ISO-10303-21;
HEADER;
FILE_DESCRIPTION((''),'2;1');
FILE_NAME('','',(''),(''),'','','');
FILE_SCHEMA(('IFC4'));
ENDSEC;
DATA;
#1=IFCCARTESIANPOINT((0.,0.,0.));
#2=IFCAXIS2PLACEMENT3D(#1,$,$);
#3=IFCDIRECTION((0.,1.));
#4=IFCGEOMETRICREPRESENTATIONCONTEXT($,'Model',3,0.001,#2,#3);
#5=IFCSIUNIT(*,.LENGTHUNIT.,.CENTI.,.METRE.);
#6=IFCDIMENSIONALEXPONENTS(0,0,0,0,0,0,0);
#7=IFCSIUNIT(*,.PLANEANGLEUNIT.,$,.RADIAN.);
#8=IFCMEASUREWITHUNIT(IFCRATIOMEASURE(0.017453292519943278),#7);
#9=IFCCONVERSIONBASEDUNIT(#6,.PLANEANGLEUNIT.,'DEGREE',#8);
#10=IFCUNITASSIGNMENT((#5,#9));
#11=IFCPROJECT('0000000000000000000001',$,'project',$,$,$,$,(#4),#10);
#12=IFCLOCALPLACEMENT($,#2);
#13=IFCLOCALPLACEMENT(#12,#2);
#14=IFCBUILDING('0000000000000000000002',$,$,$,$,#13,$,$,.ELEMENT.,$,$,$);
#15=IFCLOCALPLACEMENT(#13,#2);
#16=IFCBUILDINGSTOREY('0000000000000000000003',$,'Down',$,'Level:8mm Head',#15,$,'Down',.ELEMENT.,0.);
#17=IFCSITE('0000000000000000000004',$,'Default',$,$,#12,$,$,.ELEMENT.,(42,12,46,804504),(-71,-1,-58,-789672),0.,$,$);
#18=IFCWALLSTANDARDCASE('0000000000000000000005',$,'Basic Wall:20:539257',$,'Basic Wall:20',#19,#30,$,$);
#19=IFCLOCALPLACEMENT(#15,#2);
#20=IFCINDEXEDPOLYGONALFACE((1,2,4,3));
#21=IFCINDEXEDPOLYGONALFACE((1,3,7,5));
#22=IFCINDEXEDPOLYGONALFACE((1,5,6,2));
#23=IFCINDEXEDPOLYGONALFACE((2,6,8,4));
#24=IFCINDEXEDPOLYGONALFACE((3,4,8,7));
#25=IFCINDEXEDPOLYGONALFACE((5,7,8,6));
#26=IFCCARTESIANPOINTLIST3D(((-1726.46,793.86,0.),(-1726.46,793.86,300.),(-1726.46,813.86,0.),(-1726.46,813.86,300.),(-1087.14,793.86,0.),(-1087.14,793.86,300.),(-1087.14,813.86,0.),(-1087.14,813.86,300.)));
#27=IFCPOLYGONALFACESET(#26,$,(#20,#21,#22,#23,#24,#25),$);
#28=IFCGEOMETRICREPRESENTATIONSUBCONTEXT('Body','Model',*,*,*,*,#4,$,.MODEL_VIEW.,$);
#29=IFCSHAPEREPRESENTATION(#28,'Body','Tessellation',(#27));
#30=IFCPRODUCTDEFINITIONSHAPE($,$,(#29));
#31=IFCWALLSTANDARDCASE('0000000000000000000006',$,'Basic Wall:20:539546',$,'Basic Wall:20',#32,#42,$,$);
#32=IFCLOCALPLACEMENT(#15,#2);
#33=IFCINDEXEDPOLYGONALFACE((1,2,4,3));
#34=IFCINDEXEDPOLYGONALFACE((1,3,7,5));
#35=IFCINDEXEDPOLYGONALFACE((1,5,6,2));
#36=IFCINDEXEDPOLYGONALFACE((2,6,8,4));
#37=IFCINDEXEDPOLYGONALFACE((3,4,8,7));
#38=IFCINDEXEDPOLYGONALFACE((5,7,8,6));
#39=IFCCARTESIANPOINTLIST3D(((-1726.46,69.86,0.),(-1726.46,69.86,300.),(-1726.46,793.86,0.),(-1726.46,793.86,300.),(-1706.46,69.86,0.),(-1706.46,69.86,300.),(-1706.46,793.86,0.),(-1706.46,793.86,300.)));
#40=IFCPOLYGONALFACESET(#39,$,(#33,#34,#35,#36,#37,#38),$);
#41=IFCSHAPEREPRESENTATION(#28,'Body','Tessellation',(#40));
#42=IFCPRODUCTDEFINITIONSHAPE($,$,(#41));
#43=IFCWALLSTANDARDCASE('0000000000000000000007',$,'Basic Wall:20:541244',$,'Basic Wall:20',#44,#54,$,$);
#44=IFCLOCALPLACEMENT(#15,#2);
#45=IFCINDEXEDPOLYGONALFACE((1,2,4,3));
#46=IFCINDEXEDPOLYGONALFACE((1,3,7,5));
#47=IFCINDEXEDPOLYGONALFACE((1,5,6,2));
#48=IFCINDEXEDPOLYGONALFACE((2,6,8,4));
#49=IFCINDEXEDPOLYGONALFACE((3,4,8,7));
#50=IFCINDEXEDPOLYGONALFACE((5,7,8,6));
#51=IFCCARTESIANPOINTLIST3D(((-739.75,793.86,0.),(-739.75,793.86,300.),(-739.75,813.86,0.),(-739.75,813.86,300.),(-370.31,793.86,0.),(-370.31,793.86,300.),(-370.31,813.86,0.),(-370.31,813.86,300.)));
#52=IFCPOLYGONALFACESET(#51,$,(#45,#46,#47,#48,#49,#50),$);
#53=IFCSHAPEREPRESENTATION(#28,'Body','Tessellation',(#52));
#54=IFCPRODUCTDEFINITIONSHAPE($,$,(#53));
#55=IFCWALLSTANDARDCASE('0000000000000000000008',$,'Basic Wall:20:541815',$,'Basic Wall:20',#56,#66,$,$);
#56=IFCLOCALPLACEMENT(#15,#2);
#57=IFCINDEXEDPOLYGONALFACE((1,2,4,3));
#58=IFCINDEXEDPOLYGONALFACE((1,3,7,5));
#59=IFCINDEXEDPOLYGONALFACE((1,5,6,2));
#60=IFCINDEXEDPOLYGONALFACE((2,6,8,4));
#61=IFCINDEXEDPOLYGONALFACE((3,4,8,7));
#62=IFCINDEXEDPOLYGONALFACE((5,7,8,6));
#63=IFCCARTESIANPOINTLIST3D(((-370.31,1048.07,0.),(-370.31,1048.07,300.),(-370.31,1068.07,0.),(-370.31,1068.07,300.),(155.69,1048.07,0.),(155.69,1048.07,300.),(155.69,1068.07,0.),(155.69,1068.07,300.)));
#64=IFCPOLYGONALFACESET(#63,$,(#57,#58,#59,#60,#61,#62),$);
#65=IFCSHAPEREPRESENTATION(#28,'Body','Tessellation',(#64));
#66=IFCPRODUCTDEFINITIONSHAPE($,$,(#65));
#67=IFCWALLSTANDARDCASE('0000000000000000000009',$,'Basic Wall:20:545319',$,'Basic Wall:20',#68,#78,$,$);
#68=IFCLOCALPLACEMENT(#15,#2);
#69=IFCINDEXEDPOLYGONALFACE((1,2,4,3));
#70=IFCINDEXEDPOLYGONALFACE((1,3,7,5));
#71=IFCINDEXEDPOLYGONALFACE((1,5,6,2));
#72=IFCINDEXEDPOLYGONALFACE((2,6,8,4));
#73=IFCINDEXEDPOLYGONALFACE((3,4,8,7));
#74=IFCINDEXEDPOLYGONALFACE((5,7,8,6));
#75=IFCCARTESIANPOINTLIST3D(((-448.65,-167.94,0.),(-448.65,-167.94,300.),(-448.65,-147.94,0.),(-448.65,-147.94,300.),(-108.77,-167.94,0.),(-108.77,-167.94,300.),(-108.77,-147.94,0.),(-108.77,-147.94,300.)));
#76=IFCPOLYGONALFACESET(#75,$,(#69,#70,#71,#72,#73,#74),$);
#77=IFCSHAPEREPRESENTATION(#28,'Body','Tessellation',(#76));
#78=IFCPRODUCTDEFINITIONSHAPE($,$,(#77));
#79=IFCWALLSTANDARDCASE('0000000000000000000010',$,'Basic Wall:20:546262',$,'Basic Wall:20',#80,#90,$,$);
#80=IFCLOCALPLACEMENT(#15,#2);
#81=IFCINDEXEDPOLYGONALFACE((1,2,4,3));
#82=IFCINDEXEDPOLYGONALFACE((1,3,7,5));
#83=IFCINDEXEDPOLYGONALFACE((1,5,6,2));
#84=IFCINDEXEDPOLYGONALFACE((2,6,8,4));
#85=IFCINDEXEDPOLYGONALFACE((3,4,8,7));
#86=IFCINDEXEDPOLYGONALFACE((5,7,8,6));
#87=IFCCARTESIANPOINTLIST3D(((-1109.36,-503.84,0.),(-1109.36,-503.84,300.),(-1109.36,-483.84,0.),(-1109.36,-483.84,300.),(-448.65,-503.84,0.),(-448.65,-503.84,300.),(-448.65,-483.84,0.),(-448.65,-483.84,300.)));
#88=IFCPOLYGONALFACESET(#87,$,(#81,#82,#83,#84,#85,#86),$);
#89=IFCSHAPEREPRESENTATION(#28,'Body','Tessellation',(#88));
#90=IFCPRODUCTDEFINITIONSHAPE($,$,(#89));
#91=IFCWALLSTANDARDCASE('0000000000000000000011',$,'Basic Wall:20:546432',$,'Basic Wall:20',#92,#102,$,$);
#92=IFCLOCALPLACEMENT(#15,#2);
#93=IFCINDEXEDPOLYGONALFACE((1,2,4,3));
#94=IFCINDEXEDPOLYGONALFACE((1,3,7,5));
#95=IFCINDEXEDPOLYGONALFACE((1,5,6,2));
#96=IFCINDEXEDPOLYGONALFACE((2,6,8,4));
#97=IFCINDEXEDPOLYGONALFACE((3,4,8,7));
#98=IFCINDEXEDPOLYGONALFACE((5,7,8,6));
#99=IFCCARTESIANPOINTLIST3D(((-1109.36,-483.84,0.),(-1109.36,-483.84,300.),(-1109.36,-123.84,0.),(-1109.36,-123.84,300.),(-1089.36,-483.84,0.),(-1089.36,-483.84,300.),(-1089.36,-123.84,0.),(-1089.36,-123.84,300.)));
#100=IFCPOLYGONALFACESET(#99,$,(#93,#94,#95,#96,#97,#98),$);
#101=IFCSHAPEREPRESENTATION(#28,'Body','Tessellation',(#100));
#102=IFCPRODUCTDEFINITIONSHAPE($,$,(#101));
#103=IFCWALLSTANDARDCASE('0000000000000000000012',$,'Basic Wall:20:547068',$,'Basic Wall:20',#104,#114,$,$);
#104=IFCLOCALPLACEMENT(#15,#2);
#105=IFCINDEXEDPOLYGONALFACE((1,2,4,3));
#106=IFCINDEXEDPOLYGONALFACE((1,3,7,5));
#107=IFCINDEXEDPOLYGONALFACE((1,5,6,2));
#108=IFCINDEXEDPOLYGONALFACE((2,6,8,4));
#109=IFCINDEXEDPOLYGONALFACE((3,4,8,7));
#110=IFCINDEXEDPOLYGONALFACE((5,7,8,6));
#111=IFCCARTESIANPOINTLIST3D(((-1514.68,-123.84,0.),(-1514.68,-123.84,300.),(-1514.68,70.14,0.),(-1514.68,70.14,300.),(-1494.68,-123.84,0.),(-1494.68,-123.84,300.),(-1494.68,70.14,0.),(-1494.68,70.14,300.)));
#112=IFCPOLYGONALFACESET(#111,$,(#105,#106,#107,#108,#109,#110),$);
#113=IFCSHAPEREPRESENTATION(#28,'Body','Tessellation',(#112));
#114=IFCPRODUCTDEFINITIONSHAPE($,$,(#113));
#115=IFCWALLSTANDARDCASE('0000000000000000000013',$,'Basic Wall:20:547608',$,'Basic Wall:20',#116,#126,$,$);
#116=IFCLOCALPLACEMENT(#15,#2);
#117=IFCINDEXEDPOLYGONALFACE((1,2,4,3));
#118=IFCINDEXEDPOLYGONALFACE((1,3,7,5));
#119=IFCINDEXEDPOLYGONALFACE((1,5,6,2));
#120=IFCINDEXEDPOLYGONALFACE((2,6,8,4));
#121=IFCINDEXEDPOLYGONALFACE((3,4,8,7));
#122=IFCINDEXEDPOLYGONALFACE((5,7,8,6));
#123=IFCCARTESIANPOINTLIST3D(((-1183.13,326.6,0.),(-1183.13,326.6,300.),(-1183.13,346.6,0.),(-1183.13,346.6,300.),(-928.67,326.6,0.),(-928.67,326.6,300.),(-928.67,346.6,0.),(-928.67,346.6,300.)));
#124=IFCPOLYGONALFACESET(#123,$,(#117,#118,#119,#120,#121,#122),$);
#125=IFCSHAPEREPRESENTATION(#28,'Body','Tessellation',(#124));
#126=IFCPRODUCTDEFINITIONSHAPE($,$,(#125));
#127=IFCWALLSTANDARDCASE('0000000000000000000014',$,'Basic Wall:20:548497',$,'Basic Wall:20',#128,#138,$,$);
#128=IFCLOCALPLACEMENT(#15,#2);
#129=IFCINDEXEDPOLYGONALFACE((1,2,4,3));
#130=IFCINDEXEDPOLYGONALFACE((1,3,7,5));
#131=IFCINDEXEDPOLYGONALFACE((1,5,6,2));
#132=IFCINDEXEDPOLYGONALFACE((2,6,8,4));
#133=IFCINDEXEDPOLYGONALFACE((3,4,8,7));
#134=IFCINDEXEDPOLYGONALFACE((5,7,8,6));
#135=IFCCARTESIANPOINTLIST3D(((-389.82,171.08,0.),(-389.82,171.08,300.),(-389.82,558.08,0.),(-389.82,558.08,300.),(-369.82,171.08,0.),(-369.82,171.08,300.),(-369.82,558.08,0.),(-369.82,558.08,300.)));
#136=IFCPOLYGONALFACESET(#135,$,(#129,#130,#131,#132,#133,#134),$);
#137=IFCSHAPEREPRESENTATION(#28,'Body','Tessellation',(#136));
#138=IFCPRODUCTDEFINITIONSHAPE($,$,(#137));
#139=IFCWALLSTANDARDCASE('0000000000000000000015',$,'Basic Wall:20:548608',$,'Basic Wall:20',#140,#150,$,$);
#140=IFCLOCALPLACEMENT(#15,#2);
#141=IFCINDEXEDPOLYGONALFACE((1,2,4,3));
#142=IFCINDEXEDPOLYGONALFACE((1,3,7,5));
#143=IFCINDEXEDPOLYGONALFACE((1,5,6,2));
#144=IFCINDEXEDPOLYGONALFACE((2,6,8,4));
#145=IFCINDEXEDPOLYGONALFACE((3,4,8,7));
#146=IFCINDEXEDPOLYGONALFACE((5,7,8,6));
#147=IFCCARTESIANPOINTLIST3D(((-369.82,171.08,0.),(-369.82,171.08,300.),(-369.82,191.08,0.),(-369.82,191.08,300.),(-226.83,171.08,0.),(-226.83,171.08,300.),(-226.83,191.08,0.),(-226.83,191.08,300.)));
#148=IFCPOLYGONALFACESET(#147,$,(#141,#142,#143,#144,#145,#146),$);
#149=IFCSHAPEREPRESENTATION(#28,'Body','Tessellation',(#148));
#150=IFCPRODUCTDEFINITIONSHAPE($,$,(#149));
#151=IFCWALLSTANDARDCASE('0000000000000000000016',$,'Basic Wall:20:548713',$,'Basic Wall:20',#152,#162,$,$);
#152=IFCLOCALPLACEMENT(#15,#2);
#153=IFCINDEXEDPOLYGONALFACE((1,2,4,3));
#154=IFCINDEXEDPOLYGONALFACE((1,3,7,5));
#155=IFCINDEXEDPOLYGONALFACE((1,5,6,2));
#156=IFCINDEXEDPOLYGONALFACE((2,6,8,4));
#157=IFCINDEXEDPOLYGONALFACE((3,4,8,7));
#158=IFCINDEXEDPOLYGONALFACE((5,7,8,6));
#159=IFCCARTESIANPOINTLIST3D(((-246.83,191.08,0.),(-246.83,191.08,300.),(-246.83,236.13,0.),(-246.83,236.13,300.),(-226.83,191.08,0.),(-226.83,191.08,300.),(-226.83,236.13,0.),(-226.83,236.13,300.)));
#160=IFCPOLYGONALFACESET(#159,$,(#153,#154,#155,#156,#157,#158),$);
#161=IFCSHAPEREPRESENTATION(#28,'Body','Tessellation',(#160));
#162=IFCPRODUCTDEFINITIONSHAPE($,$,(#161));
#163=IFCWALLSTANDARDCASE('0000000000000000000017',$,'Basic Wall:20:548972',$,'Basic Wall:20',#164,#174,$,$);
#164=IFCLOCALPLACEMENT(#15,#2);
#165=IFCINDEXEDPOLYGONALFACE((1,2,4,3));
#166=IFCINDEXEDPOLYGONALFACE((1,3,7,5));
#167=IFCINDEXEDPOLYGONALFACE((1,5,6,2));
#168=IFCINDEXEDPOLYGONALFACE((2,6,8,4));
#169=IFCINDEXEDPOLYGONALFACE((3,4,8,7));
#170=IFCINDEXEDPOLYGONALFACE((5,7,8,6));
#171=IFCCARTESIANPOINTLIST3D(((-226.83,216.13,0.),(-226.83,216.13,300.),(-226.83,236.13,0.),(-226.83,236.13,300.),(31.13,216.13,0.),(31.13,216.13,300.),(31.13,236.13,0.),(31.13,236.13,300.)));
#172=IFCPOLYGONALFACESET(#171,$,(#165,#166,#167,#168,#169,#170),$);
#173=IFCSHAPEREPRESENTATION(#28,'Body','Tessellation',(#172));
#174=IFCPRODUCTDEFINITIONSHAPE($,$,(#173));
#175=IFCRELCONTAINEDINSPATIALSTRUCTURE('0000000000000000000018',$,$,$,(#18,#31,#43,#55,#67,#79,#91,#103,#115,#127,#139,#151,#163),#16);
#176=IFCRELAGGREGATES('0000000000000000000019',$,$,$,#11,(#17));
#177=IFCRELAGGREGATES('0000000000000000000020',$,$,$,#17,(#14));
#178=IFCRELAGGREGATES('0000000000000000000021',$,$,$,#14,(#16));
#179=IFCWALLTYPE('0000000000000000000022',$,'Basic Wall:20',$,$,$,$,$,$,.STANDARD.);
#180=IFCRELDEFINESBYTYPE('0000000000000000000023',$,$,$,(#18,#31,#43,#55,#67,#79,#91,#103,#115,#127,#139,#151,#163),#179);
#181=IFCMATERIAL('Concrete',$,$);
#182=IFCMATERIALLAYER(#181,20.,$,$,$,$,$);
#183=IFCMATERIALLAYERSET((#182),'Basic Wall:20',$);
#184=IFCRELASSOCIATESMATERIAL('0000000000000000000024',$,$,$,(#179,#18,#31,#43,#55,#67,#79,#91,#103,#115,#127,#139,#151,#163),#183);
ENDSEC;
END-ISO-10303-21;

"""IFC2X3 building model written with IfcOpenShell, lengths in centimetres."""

from ifc_helpers import new_model, entity, si_unit, converted_unit, direction, frame, frame_2d, origin, place, context, subcontext, project, spatial, rectangle, extrude, material, layer, layer_set, layer_usage, type_object, element, save


model = new_model("IFC2X3")

# Units and contexts
model_context = context("Model", 3, precision=0.001, world=origin(), true_north=direction((0.0, 1.0)))
body_context = subcontext(model_context, "Body", "Model", "MODEL_VIEW")
ifc_project = project(units=[si_unit("LENGTHUNIT", "METRE", prefix="CENTI"), converted_unit("PLANEANGLEUNIT", "DEGREE", entity("IfcRatioMeasure", 0.017453292519943278), si_unit("PLANEANGLEUNIT", "RADIAN"), dimensions=[0, 0, 0, 0, 0, 0, 0])], contexts=[model_context])

# Site, building, storey
site_placement = place(None, origin())
site = spatial("IfcSite", under=ifc_project, at=site_placement, Name="Default", CompositionType="ELEMENT", RefLatitude=(42, 12, 46, 804504), RefLongitude=(-71, -1, -58, -789672), RefElevation=0.0)
building_placement = place(site_placement, origin())
building = spatial("IfcBuilding", under=site, at=building_placement, CompositionType="ELEMENT")
storey_placement = place(building_placement, origin())
storey = spatial("IfcBuildingStorey", under=building, at=storey_placement, Name="Down", ObjectType="Level:8mm Head", LongName="Down", CompositionType="ELEMENT", Elevation=0.0)

# Walls
ifc_material = material(Name="Concrete")
ifc_layer_1 = layer(ifc_material, 20.0)
ifc_layer_set_1 = layer_set([ifc_layer_1], Name="Basic Wall:20")
ifc_layer_usage_1 = layer_usage(ifc_layer_set_1, "AXIS2", "NEGATIVE", 10.0)
wall_type_1 = type_object("IfcWallType", Name="Basic Wall:20", PredefinedType="STANDARD", material=ifc_layer_set_1)
wall_1_placement = place(storey_placement, frame((-1726.46, 803.86, 0.0)))
element("IfcWallStandardCase", 1, at=wall_1_placement, inside=storey, type_object=wall_type_1, material=ifc_layer_usage_1, Name="Basic Wall:20:539257", ObjectType="Basic Wall:20", context=body_context, shape_type="SweptSolid", body=[
    extrude(rectangle(XDim=639.32, YDim=20.0, at=frame_2d((319.66, 0.0), x_axis=(-1.0, 0.0))), origin(), (0.0, 0.0, 1.0), 300.0),
])
ifc_layer_usage_2 = layer_usage(ifc_layer_set_1, "AXIS2", "POSITIVE", -10.0)
wall_2_placement = place(storey_placement, frame((-1716.46, 793.86, 0.0), z_axis=(0.0, 0.0, 1.0), x_axis=(0.0, -1.0, 0.0)))
element("IfcWallStandardCase", 2, at=wall_2_placement, inside=storey, type_object=wall_type_1, material=ifc_layer_usage_2, Name="Basic Wall:20:539546", ObjectType="Basic Wall:20", context=body_context, shape_type="SweptSolid", body=[
    extrude(rectangle(XDim=724.0, YDim=20.0, at=frame_2d((362.0, 0.0), x_axis=(-1.0, 0.0))), origin(), (0.0, 0.0, 1.0), 300.0),
])
ifc_layer_usage_3 = layer_usage(ifc_layer_set_1, "AXIS2", "NEGATIVE", 10.0)
wall_3_placement = place(storey_placement, frame((-739.75, 803.86, 0.0)))
element("IfcWallStandardCase", 3, at=wall_3_placement, inside=storey, type_object=wall_type_1, material=ifc_layer_usage_3, Name="Basic Wall:20:541244", ObjectType="Basic Wall:20", context=body_context, shape_type="SweptSolid", body=[
    extrude(rectangle(XDim=369.44, YDim=20.0, at=frame_2d((184.72, 0.0), x_axis=(-1.0, 0.0))), origin(), (0.0, 0.0, 1.0), 300.0),
])
ifc_layer_usage_4 = layer_usage(ifc_layer_set_1, "AXIS2", "NEGATIVE", 10.0)
wall_4_placement = place(storey_placement, frame((-370.31, 1058.07, 0.0)))
element("IfcWallStandardCase", 4, at=wall_4_placement, inside=storey, type_object=wall_type_1, material=ifc_layer_usage_4, Name="Basic Wall:20:541815", ObjectType="Basic Wall:20", context=body_context, shape_type="SweptSolid", body=[
    extrude(rectangle(XDim=526.0, YDim=20.0, at=frame_2d((263.0, 0.0), x_axis=(-1.0, 0.0))), origin(), (0.0, 0.0, 1.0), 300.0),
])
ifc_layer_usage_5 = layer_usage(ifc_layer_set_1, "AXIS2", "POSITIVE", -10.0)
wall_5_placement = place(storey_placement, frame((-108.77, -157.94, 0.0), z_axis=(0.0, 0.0, 1.0), x_axis=(-1.0, 0.0, 0.0)))
element("IfcWallStandardCase", 5, at=wall_5_placement, inside=storey, type_object=wall_type_1, material=ifc_layer_usage_5, Name="Basic Wall:20:545319", ObjectType="Basic Wall:20", context=body_context, shape_type="SweptSolid", body=[
    extrude(rectangle(XDim=339.88, YDim=20.0, at=frame_2d((169.94, 0.0), x_axis=(-1.0, 0.0))), origin(), (0.0, 0.0, 1.0), 300.0),
])
ifc_layer_usage_6 = layer_usage(ifc_layer_set_1, "AXIS2", "NEGATIVE", 10.0)
wall_6_placement = place(storey_placement, frame((-448.65, -493.84, 0.0), z_axis=(0.0, 0.0, 1.0), x_axis=(-1.0, 0.0, 0.0)))
element("IfcWallStandardCase", 6, at=wall_6_placement, inside=storey, type_object=wall_type_1, material=ifc_layer_usage_6, Name="Basic Wall:20:546262", ObjectType="Basic Wall:20", context=body_context, shape_type="SweptSolid", body=[
    extrude(rectangle(XDim=660.71, YDim=20.0, at=frame_2d((330.36, 0.0), x_axis=(-1.0, 0.0))), origin(), (0.0, 0.0, 1.0), 300.0),
])
ifc_layer_usage_7 = layer_usage(ifc_layer_set_1, "AXIS2", "NEGATIVE", 10.0)
wall_7_placement = place(storey_placement, frame((-1099.36, -483.84, 0.0), z_axis=(0.0, 0.0, 1.0), x_axis=(0.0, 1.0, 0.0)))
element("IfcWallStandardCase", 7, at=wall_7_placement, inside=storey, type_object=wall_type_1, material=ifc_layer_usage_7, Name="Basic Wall:20:546432", ObjectType="Basic Wall:20", context=body_context, shape_type="SweptSolid", body=[
    extrude(rectangle(XDim=360.0, YDim=20.0, at=frame_2d((180.0, 0.0), x_axis=(-1.0, 0.0))), origin(), (0.0, 0.0, 1.0), 300.0),
])
ifc_layer_usage_8 = layer_usage(ifc_layer_set_1, "AXIS2", "POSITIVE", -10.0)
wall_8_placement = place(storey_placement, frame((-1504.68, -123.84, 0.0), z_axis=(0.0, 0.0, 1.0), x_axis=(0.0, 1.0, 0.0)))
element("IfcWallStandardCase", 8, at=wall_8_placement, inside=storey, type_object=wall_type_1, material=ifc_layer_usage_8, Name="Basic Wall:20:547068", ObjectType="Basic Wall:20", context=body_context, shape_type="SweptSolid", body=[
    extrude(rectangle(XDim=193.98, YDim=20.0, at=frame_2d((96.99, 0.0), x_axis=(-1.0, 0.0))), origin(), (0.0, 0.0, 1.0), 300.0),
])
ifc_layer_usage_9 = layer_usage(ifc_layer_set_1, "AXIS2", "NEGATIVE", 10.0)
wall_9_placement = place(storey_placement, frame((-928.67, 336.6, 0.0), z_axis=(0.0, 0.0, 1.0), x_axis=(-1.0, 0.0, 0.0)))
element("IfcWallStandardCase", 9, at=wall_9_placement, inside=storey, type_object=wall_type_1, material=ifc_layer_usage_9, Name="Basic Wall:20:547608", ObjectType="Basic Wall:20", context=body_context, shape_type="SweptSolid", body=[
    extrude(rectangle(XDim=254.47, YDim=20.0, at=frame_2d((127.23, 0.0), x_axis=(-1.0, 0.0))), origin(), (0.0, 0.0, 1.0), 300.0),
])
ifc_layer_usage_10 = layer_usage(ifc_layer_set_1, "AXIS2", "POSITIVE", -10.0)
wall_10_placement = place(storey_placement, frame((-379.82, 558.08, 0.0), z_axis=(0.0, 0.0, 1.0), x_axis=(0.0, -1.0, 0.0)))
element("IfcWallStandardCase", 10, at=wall_10_placement, inside=storey, type_object=wall_type_1, material=ifc_layer_usage_10, Name="Basic Wall:20:548497", ObjectType="Basic Wall:20", context=body_context, shape_type="SweptSolid", body=[
    extrude(rectangle(XDim=386.99, YDim=20.0, at=frame_2d((193.5, 0.0), x_axis=(-1.0, 0.0))), origin(), (0.0, 0.0, 1.0), 300.0),
])
ifc_layer_usage_11 = layer_usage(ifc_layer_set_1, "AXIS2", "POSITIVE", -10.0)
wall_11_placement = place(storey_placement, frame((-369.82, 181.08, 0.0)))
element("IfcWallStandardCase", 11, at=wall_11_placement, inside=storey, type_object=wall_type_1, material=ifc_layer_usage_11, Name="Basic Wall:20:548608", ObjectType="Basic Wall:20", context=body_context, shape_type="SweptSolid", body=[
    extrude(rectangle(XDim=143.0, YDim=20.0, at=frame_2d((71.5, 0.0), x_axis=(-1.0, 0.0))), origin(), (0.0, 0.0, 1.0), 300.0),
])
ifc_layer_usage_12 = layer_usage(ifc_layer_set_1, "AXIS2", "POSITIVE", -10.0)
wall_12_placement = place(storey_placement, frame((-236.83, 191.08, 0.0), z_axis=(0.0, 0.0, 1.0), x_axis=(0.0, 1.0, 0.0)))
element("IfcWallStandardCase", 12, at=wall_12_placement, inside=storey, type_object=wall_type_1, material=ifc_layer_usage_12, Name="Basic Wall:20:548713", ObjectType="Basic Wall:20", context=body_context, shape_type="SweptSolid", body=[
    extrude(rectangle(XDim=45.05, YDim=20.0, at=frame_2d((22.52, 0.0), x_axis=(-1.0, 0.0))), origin(), (0.0, 0.0, 1.0), 300.0),
])
ifc_layer_usage_13 = layer_usage(ifc_layer_set_1, "AXIS2", "NEGATIVE", 10.0)
wall_13_placement = place(storey_placement, frame((-226.83, 226.13, 0.0)))
element("IfcWallStandardCase", 13, at=wall_13_placement, inside=storey, type_object=wall_type_1, material=ifc_layer_usage_13, Name="Basic Wall:20:548972", ObjectType="Basic Wall:20", context=body_context, shape_type="SweptSolid", body=[
    extrude(rectangle(XDim=257.96, YDim=20.0, at=frame_2d((128.98, 0.0), x_axis=(-1.0, 0.0))), origin(), (0.0, 0.0, 1.0), 300.0),
])

save(model, "model.ifc")
